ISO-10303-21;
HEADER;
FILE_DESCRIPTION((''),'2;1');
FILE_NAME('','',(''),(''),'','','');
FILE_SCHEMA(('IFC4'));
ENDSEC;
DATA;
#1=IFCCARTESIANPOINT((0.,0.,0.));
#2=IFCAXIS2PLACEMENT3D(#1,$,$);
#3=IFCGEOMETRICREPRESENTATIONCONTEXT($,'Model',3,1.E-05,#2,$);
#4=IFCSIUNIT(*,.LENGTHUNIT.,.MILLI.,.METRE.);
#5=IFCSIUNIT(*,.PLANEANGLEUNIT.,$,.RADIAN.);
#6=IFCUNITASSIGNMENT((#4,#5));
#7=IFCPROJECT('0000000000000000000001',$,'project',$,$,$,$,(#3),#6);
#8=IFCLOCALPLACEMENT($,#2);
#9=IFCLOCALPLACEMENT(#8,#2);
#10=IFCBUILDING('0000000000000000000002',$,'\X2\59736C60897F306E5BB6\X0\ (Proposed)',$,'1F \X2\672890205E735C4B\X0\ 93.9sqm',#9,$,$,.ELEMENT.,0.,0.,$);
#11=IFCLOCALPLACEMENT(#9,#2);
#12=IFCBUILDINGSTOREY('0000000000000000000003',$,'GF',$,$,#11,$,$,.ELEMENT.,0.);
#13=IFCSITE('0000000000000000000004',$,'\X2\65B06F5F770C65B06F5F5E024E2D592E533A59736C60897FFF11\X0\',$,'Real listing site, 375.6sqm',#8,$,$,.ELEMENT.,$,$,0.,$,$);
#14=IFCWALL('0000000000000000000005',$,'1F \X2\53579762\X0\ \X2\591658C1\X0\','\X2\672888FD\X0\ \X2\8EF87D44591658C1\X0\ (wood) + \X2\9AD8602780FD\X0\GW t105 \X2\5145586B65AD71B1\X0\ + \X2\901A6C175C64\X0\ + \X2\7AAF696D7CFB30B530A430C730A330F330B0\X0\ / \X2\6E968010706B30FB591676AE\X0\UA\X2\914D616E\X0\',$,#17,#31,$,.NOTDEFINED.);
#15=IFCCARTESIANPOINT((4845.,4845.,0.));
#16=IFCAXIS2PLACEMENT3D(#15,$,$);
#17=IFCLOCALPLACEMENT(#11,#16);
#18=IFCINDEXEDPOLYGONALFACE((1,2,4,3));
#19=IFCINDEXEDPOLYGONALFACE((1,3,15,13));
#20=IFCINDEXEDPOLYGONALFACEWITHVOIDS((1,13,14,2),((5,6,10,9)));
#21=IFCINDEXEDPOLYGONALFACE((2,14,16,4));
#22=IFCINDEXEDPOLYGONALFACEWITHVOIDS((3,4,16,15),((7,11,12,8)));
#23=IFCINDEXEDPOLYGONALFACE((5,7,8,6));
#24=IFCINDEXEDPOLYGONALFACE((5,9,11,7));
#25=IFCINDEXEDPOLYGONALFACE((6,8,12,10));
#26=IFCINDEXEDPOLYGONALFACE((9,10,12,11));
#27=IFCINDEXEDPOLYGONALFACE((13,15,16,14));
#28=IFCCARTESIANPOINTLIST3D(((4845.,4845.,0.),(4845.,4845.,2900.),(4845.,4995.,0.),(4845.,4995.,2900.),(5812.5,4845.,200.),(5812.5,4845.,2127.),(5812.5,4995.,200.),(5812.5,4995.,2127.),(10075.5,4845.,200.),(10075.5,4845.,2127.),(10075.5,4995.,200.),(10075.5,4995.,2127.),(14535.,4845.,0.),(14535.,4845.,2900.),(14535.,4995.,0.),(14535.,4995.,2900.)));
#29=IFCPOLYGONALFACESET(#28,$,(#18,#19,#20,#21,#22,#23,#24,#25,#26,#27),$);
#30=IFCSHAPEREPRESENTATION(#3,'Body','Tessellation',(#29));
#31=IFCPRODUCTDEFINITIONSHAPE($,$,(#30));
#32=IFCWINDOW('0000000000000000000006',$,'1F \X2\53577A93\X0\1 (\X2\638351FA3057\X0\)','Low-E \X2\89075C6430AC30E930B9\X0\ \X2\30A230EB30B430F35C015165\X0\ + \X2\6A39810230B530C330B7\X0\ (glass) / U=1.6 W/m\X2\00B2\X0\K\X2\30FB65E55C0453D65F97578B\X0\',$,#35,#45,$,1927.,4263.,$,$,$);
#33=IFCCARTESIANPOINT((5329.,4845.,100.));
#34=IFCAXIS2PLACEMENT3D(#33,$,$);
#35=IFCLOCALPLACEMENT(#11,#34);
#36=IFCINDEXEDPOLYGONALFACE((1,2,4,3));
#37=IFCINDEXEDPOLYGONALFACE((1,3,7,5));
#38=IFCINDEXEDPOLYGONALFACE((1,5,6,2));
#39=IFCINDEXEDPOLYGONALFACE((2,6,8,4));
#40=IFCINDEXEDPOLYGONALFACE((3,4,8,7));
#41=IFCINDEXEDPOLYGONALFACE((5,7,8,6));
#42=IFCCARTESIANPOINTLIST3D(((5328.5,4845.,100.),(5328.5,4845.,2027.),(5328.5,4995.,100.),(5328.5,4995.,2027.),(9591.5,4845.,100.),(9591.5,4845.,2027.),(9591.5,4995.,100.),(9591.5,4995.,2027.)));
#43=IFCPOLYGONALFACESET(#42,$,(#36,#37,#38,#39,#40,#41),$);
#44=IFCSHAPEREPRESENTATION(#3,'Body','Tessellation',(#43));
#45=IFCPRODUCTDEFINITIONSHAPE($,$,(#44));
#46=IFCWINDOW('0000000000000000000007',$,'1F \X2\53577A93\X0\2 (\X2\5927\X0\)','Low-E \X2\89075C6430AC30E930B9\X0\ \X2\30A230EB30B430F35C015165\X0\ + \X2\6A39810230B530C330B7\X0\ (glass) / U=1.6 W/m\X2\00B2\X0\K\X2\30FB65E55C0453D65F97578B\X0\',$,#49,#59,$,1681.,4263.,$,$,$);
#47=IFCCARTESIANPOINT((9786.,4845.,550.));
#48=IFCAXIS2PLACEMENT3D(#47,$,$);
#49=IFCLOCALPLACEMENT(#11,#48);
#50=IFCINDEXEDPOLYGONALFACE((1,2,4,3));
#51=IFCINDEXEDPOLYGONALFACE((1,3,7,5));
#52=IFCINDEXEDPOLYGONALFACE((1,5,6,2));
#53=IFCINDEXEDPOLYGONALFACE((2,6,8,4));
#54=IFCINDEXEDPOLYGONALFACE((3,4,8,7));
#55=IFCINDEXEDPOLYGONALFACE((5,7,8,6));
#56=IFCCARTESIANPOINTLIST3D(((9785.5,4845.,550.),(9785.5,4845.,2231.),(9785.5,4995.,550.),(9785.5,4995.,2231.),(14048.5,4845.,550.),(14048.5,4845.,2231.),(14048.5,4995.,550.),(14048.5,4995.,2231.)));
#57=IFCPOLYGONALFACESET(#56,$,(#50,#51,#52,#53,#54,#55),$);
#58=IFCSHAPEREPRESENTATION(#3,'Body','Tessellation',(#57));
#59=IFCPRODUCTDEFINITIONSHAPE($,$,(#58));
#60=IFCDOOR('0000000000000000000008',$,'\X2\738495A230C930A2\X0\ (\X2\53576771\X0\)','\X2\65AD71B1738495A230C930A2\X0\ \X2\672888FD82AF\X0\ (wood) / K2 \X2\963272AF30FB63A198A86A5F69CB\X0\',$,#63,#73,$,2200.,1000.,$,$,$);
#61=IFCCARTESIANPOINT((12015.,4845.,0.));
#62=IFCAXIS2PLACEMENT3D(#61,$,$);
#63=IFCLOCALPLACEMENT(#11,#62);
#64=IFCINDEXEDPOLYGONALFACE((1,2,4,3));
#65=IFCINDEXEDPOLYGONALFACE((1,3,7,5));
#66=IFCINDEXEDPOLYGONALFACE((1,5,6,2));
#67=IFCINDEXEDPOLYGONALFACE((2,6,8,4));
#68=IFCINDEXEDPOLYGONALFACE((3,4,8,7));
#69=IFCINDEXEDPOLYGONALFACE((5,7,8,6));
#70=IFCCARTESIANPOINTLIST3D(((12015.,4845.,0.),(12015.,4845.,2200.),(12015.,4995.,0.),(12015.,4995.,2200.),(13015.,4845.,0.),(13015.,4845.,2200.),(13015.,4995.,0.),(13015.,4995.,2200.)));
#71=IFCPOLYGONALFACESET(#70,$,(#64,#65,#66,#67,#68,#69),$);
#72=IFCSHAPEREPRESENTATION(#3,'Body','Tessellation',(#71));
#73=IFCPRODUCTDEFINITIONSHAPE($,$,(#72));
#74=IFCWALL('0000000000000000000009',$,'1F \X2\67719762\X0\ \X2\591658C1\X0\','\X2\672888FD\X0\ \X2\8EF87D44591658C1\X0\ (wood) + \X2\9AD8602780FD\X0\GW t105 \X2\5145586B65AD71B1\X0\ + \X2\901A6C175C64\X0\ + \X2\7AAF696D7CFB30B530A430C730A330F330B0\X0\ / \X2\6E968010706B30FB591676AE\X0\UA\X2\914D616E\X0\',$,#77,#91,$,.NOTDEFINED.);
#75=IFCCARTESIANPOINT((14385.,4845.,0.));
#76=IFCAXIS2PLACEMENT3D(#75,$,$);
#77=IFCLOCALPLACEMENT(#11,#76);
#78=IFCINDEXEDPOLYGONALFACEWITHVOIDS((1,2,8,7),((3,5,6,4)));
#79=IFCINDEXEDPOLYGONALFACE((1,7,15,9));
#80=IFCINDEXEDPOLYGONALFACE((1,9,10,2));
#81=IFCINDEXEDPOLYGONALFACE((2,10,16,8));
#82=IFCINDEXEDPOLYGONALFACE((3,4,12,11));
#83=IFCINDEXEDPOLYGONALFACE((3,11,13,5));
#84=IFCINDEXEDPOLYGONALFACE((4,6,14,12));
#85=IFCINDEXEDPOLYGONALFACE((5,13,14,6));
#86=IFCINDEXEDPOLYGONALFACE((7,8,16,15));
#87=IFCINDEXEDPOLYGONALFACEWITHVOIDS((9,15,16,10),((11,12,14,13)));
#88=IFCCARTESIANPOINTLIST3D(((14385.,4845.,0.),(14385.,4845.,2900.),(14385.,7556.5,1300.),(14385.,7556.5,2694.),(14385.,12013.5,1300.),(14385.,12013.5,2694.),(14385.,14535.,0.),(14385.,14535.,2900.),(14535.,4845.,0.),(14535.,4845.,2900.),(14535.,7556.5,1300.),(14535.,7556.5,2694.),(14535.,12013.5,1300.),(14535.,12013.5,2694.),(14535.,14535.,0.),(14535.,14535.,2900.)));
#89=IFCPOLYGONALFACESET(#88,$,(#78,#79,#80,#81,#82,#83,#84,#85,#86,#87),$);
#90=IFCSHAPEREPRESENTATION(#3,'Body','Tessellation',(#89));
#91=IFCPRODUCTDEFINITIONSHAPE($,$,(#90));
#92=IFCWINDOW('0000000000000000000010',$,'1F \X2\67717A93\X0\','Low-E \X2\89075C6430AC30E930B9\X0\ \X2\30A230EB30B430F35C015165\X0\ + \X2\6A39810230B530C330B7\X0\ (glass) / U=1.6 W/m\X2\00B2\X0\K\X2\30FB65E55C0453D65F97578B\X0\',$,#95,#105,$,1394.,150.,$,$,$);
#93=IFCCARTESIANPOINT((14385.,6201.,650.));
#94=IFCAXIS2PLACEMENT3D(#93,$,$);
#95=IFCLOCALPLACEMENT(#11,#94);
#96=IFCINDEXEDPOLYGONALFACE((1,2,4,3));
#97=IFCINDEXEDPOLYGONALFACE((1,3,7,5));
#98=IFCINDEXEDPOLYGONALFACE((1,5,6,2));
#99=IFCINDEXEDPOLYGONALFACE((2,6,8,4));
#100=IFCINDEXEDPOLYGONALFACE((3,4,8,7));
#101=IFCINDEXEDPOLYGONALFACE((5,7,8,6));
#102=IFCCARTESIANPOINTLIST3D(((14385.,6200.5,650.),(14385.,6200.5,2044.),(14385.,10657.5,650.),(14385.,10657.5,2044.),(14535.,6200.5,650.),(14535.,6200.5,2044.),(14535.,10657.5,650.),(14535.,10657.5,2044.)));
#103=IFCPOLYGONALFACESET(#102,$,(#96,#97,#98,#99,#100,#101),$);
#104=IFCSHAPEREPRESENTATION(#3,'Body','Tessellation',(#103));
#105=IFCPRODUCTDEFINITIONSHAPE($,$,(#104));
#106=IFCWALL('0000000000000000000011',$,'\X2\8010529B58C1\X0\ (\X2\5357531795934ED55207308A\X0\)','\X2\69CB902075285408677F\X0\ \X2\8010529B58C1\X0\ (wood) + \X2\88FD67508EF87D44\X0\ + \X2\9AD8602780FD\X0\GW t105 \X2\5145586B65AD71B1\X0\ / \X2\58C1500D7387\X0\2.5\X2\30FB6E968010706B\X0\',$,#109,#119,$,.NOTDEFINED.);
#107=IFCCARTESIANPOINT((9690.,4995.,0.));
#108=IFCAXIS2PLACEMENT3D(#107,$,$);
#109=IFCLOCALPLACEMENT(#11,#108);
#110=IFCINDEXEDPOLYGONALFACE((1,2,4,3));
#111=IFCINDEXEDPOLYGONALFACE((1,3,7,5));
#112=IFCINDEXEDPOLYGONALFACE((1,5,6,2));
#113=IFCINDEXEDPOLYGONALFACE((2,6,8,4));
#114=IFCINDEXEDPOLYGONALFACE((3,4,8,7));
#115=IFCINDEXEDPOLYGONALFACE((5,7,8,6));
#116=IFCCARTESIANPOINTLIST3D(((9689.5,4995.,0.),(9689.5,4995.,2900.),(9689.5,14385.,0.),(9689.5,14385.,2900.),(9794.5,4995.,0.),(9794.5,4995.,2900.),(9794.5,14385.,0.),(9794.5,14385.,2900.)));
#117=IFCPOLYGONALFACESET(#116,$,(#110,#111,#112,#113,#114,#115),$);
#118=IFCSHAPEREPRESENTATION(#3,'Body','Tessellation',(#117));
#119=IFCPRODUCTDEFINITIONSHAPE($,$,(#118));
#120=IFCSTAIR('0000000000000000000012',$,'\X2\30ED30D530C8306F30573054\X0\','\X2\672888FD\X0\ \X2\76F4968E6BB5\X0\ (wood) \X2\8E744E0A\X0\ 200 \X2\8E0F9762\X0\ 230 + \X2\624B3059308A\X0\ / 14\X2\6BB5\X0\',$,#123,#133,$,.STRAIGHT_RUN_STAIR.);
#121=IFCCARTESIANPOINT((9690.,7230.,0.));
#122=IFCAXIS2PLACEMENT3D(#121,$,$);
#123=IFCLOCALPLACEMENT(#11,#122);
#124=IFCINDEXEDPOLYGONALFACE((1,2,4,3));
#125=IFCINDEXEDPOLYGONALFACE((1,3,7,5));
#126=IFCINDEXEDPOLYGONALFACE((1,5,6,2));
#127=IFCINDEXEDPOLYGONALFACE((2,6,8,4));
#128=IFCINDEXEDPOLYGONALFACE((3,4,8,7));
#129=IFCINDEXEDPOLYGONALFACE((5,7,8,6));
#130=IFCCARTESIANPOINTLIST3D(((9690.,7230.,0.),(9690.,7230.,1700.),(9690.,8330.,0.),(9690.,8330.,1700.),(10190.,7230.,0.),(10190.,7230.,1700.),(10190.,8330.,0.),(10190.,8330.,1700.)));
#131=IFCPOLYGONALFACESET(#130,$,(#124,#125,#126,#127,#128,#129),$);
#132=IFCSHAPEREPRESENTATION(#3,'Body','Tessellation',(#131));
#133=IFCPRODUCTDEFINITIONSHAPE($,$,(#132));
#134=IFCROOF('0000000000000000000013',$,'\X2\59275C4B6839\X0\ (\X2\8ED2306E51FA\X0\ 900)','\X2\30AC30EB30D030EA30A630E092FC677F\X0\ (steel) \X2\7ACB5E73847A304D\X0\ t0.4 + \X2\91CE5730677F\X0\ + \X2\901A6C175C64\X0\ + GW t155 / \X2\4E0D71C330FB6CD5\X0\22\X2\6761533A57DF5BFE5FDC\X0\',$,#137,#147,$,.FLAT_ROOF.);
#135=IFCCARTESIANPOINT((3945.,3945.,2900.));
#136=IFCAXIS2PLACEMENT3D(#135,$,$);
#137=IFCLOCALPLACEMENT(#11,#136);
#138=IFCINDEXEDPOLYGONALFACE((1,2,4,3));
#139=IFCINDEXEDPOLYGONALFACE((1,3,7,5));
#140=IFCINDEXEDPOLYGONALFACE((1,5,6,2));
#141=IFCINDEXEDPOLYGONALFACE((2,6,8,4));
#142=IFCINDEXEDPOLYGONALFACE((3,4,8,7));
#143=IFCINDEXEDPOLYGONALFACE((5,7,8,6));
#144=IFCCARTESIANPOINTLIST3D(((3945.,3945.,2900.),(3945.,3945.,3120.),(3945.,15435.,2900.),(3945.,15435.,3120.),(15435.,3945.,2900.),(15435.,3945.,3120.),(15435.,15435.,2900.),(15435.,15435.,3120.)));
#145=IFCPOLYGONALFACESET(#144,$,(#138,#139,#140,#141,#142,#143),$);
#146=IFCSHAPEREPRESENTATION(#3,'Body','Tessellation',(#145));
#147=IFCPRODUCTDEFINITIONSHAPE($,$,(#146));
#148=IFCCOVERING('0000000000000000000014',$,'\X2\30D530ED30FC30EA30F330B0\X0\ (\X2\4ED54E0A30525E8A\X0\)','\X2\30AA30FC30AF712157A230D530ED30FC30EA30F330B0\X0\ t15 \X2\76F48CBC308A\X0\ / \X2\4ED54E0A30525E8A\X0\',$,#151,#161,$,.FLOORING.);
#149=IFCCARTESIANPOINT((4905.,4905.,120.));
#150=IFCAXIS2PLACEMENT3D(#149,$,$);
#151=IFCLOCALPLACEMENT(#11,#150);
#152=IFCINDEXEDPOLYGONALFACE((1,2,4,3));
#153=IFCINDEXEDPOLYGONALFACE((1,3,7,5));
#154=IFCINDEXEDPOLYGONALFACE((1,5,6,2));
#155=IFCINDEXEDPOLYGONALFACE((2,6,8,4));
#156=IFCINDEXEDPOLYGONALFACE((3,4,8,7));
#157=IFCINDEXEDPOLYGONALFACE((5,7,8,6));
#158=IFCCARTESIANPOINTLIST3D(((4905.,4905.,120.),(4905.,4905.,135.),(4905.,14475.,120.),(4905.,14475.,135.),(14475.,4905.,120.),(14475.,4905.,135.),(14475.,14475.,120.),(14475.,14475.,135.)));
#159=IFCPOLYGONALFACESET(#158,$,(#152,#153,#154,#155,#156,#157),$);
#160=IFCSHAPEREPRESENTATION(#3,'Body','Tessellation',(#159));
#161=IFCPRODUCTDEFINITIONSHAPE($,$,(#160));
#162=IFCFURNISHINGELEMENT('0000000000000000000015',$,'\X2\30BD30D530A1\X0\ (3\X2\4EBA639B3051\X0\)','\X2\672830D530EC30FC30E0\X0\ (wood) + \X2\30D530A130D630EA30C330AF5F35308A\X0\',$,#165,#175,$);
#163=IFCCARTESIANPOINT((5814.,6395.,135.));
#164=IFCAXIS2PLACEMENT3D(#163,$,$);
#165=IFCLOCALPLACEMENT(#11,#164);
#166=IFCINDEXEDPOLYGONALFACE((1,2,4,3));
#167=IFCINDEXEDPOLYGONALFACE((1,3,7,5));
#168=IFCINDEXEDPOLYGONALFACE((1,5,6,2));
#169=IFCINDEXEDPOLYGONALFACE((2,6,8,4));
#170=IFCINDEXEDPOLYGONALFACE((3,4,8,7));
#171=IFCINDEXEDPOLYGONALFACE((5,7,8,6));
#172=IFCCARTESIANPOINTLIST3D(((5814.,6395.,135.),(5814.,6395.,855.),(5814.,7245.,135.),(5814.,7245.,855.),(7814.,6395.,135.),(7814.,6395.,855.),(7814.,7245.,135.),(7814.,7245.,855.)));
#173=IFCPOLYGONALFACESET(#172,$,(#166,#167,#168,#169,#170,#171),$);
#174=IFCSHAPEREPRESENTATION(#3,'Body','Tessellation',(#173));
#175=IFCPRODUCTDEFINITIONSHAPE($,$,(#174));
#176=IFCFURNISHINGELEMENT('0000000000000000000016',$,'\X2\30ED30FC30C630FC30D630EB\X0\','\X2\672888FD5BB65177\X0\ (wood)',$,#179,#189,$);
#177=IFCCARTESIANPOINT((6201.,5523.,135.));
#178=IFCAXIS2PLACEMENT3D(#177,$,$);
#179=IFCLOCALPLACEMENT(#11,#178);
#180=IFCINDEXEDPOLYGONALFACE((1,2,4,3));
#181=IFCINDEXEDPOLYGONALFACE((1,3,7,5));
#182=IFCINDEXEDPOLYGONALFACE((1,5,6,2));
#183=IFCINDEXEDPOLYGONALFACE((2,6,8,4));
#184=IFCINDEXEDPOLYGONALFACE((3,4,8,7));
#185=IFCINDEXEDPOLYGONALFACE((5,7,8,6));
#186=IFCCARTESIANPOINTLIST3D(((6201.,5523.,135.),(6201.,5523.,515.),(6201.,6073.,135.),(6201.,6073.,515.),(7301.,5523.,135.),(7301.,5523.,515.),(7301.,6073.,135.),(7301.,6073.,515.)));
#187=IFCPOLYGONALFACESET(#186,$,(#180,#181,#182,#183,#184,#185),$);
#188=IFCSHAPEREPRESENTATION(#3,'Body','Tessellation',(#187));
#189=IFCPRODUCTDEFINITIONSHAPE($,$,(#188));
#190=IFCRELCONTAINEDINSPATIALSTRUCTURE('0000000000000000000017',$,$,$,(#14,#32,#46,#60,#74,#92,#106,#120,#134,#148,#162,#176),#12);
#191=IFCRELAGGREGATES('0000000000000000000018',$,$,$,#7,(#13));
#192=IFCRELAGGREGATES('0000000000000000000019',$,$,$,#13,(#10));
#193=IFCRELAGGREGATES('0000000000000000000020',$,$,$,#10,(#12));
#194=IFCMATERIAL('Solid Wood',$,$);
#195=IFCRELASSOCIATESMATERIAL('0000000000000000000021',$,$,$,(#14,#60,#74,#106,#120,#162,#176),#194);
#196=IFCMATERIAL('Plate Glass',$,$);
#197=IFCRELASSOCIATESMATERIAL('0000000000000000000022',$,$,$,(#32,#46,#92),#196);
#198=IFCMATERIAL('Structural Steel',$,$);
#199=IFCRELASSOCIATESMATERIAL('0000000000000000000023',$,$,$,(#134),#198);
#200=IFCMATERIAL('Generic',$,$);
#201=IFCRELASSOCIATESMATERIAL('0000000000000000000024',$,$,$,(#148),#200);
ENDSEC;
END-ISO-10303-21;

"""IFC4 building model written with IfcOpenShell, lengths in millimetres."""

from ifc_helpers import new_model, si_unit, frame, frame_2d, origin, place, context, project, spatial, rectangle, extrude, material, element, fill, save


model = new_model("IFC4")

# Units and contexts
model_context = context("Model", 3, precision=1e-05, world=origin())
ifc_project = project(units=[si_unit("LENGTHUNIT", "METRE", prefix="MILLI"), si_unit("PLANEANGLEUNIT", "RADIAN")], contexts=[model_context])

# Site, building, storey
site_placement = place(None, origin())
site = spatial("IfcSite", under=ifc_project, at=site_placement, Name="新潟県新潟市中央区女池西１", ObjectType="Real listing site, 375.6sqm", CompositionType="ELEMENT", RefElevation=0.0)
building_placement = place(site_placement, origin())
building = spatial("IfcBuilding", under=site, at=building_placement, Name="女池西の家 (Proposed)", ObjectType="1F 木造平屋 93.9sqm", CompositionType="ELEMENT", ElevationOfRefHeight=0.0, ElevationOfTerrain=0.0)
storey_placement = place(building_placement, origin())
storey = spatial("IfcBuildingStorey", under=building, at=storey_placement, Name="GF", CompositionType="ELEMENT", Elevation=0.0)

# Shared definitions
ifc_material_1 = material(Name="Solid Wood")

# Wall, openings, windows, door
wall_1_placement = place(storey_placement, frame((4845.0, 4845.0, 0.0)))
wall_1 = element("IfcWall", 1, at=wall_1_placement, inside=storey, material=ifc_material_1, Name="1F 南面 外壁", Description="木製 軸組外壁 (wood) + 高性能GW t105 充填断熱 + 通気層 + 窯業系サイディング / 準耐火・外皮UA配慮", PredefinedType="NOTDEFINED", context=model_context, shape_type="SweptSolid", body=[
    extrude(rectangle(XDim=9690.0, YDim=150.0, at=frame_2d((4845.0, 75.0))), frame((4845.0, 4845.0, 0.0)), (0.0, 0.0, 1.0), 2900.0),
])
opening_1_placement = place(storey_placement, frame((5329.0, 4845.0, 100.0)))
opening_1 = element("IfcOpeningElement", 2, at=opening_1_placement, cuts=wall_1, PredefinedType="NOTDEFINED", context=model_context, shape_type="SweptSolid", body=[
    extrude(rectangle(XDim=4263.0, YDim=150.0, at=frame_2d((2131.0, 75.0))), frame((5329.0, 4845.0, 100.0)), (0.0, 0.0, 1.0), 1927.0),
])
opening_2_placement = place(storey_placement, frame((9786.0, 4845.0, 550.0)))
opening_2 = element("IfcOpeningElement", 3, at=opening_2_placement, cuts=wall_1, PredefinedType="NOTDEFINED", context=model_context, shape_type="SweptSolid", body=[
    extrude(rectangle(XDim=4263.0, YDim=150.0, at=frame_2d((2131.0, 75.0))), frame((9786.0, 4845.0, 550.0)), (0.0, 0.0, 1.0), 1681.0),
])
opening_3_placement = place(storey_placement, frame((12015.0, 4845.0, 0.0)))
opening_3 = element("IfcOpeningElement", 4, at=opening_3_placement, cuts=wall_1, PredefinedType="NOTDEFINED", context=model_context, shape_type="SweptSolid", body=[
    extrude(rectangle(XDim=1000.0, YDim=150.0, at=frame_2d((500.0, 75.0))), frame((12015.0, 4845.0, 0.0)), (0.0, 0.0, 1.0), 2200.0),
])
ifc_material_2 = material(Name="Plate Glass")
window_1_placement = place(storey_placement, frame((5329.0, 4845.0, 100.0)))
window_1 = element("IfcWindow", 5, at=window_1_placement, inside=storey, material=ifc_material_2, Name="1F 南窓1 (掃出し)", Description="Low-E 複層ガラス アルゴン封入 + 樹脂サッシ (glass) / U=1.6 W/m²K・日射取得型", OverallHeight=1927.0, OverallWidth=4263.0, context=model_context, shape_type="SweptSolid", body=[
    extrude(rectangle(XDim=4263.0, YDim=150.0, at=frame_2d((2131.0, 75.0))), frame((5329.0, 4845.0, 100.0)), (0.0, 0.0, 1.0), 1927.0),
])
fill(opening_1, window_1)
window_2_placement = place(storey_placement, frame((9786.0, 4845.0, 550.0)))
window_2 = element("IfcWindow", 6, at=window_2_placement, inside=storey, material=ifc_material_2, Name="1F 南窓2 (大)", Description="Low-E 複層ガラス アルゴン封入 + 樹脂サッシ (glass) / U=1.6 W/m²K・日射取得型", OverallHeight=1681.0, OverallWidth=4263.0, context=model_context, shape_type="SweptSolid", body=[
    extrude(rectangle(XDim=4263.0, YDim=150.0, at=frame_2d((2131.0, 75.0))), frame((9786.0, 4845.0, 550.0)), (0.0, 0.0, 1.0), 1681.0),
])
fill(opening_2, window_2)
door_placement = place(storey_placement, frame((12015.0, 4845.0, 0.0)))
door = element("IfcDoor", 7, at=door_placement, inside=storey, material=ifc_material_1, Name="玄関ドア (南東)", Description="断熱玄関ドア 木製芯 (wood) / K2 防犯・採風機構", OverallHeight=2200.0, OverallWidth=1000.0, context=model_context, shape_type="SweptSolid", body=[
    extrude(rectangle(XDim=1000.0, YDim=150.0, at=frame_2d((500.0, 75.0))), frame((12015.0, 4845.0, 0.0)), (0.0, 0.0, 1.0), 2200.0),
])
fill(opening_3, door)

# Wall, opening, window
wall_2_placement = place(storey_placement, frame((14385.0, 4845.0, 0.0)))
wall_2 = element("IfcWall", 8, at=wall_2_placement, inside=storey, material=ifc_material_1, Name="1F 東面 外壁", Description="木製 軸組外壁 (wood) + 高性能GW t105 充填断熱 + 通気層 + 窯業系サイディング / 準耐火・外皮UA配慮", PredefinedType="NOTDEFINED", context=model_context, shape_type="SweptSolid", body=[
    extrude(rectangle(XDim=150.0, YDim=9690.0, at=frame_2d((75.0, 4845.0))), frame((14385.0, 4845.0, 0.0)), (0.0, 0.0, 1.0), 2900.0),
])
opening_4_placement = place(storey_placement, frame((14385.0, 6201.0, 650.0)))
opening_4 = element("IfcOpeningElement", 9, at=opening_4_placement, cuts=wall_2, PredefinedType="NOTDEFINED", context=model_context, shape_type="SweptSolid", body=[
    extrude(rectangle(XDim=150.0, YDim=4457.0, at=frame_2d((75.0, 2228.0))), frame((14385.0, 6201.0, 650.0)), (0.0, 0.0, 1.0), 1394.0),
])
window_3_placement = place(storey_placement, frame((14385.0, 6201.0, 650.0)))
window_3 = element("IfcWindow", 10, at=window_3_placement, inside=storey, material=ifc_material_2, Name="1F 東窓", Description="Low-E 複層ガラス アルゴン封入 + 樹脂サッシ (glass) / U=1.6 W/m²K・日射取得型", OverallHeight=1394.0, OverallWidth=150.0, context=model_context, shape_type="SweptSolid", body=[
    extrude(rectangle(XDim=150.0, YDim=4457.0, at=frame_2d((75.0, 2228.0))), frame((14385.0, 6201.0, 650.0)), (0.0, 0.0, 1.0), 1394.0),
])
fill(opening_4, window_3)

# Wall
wall_3_placement = place(storey_placement, frame((9690.0, 4995.0, 0.0)))
element("IfcWall", 11, at=wall_3_placement, inside=storey, material=ifc_material_1, Name="耐力壁 (南北間仕切り)", Description="構造用合板 耐力壁 (wood) + 製材軸組 + 高性能GW t105 充填断熱 / 壁倍率2.5・準耐火", PredefinedType="NOTDEFINED", context=model_context, shape_type="SweptSolid", body=[
    extrude(rectangle(XDim=105.0, YDim=9390.0, at=frame_2d((52.0, 4695.0))), frame((9690.0, 4995.0, 0.0)), (0.0, 0.0, 1.0), 2900.0),
])

# Stair
stair_placement = place(storey_placement, frame((9690.0, 7230.0, 0.0)))
element("IfcStair", 12, at=stair_placement, inside=storey, material=ifc_material_1, Name="ロフトはしご", Description="木製 直階段 (wood) 蹴上 200 踏面 230 + 手すり / 14段", PredefinedType="STRAIGHT_RUN_STAIR", context=model_context, shape_type="SweptSolid", body=[
    extrude(rectangle(XDim=500.0, YDim=1100.0, at=frame_2d((250.0, 550.0))), frame((9690.0, 7230.0, 0.0)), (0.0, 0.0, 1.0), 1700.0),
])

# Roof
ifc_material_3 = material(Name="Structural Steel")
roof_placement = place(storey_placement, frame((3945.0, 3945.0, 2900.0)))
element("IfcRoof", 13, at=roof_placement, inside=storey, material=ifc_material_3, Name="大屋根 (軒の出 900)", Description="ガルバリウム鋼板 (steel) 立平葺き t0.4 + 野地板 + 通気層 + GW t155 / 不燃・法22条区域対応", PredefinedType="FLAT_ROOF", context=model_context, shape_type="SweptSolid", body=[
    extrude(rectangle(XDim=11490.0, YDim=11490.0, at=frame_2d((5745.0, 5745.0))), frame((3945.0, 3945.0, 2900.0)), (0.0, 0.0, 1.0), 220.0),
])

# Covering
ifc_material_4 = material(Name="Generic")
covering_placement = place(storey_placement, frame((4905.0, 4905.0, 120.0)))
element("IfcCovering", 14, at=covering_placement, inside=storey, material=ifc_material_4, Name="フローリング (仕上げ床)", Description="オーク無垢フローリング t15 直貼り / 仕上げ床", PredefinedType="FLOORING", context=model_context, shape_type="SweptSolid", body=[
    extrude(rectangle(XDim=9570.0, YDim=9570.0, at=frame_2d((4785.0, 4785.0))), frame((4905.0, 4905.0, 120.0)), (0.0, 0.0, 1.0), 15.0),
])

# Furnishing elements
furnishing_1_placement = place(storey_placement, frame((5814.0, 6395.0, 135.0)))
element("IfcFurnishingElement", 15, at=furnishing_1_placement, inside=storey, material=ifc_material_1, Name="ソファ (3人掛け)", Description="木フレーム (wood) + ファブリック張り", context=model_context, shape_type="SweptSolid", body=[
    extrude(rectangle(XDim=2000.0, YDim=850.0, at=frame_2d((1000.0, 425.0))), frame((5814.0, 6395.0, 135.0)), (0.0, 0.0, 1.0), 720.0),
])
furnishing_2_placement = place(storey_placement, frame((6201.0, 5523.0, 135.0)))
element("IfcFurnishingElement", 16, at=furnishing_2_placement, inside=storey, material=ifc_material_1, Name="ローテーブル", Description="木製家具 (wood)", context=model_context, shape_type="SweptSolid", body=[
    extrude(rectangle(XDim=1100.0, YDim=550.0, at=frame_2d((550.0, 275.0))), frame((6201.0, 5523.0, 135.0)), (0.0, 0.0, 1.0), 380.0),
])

save(model, "model.ifc")
